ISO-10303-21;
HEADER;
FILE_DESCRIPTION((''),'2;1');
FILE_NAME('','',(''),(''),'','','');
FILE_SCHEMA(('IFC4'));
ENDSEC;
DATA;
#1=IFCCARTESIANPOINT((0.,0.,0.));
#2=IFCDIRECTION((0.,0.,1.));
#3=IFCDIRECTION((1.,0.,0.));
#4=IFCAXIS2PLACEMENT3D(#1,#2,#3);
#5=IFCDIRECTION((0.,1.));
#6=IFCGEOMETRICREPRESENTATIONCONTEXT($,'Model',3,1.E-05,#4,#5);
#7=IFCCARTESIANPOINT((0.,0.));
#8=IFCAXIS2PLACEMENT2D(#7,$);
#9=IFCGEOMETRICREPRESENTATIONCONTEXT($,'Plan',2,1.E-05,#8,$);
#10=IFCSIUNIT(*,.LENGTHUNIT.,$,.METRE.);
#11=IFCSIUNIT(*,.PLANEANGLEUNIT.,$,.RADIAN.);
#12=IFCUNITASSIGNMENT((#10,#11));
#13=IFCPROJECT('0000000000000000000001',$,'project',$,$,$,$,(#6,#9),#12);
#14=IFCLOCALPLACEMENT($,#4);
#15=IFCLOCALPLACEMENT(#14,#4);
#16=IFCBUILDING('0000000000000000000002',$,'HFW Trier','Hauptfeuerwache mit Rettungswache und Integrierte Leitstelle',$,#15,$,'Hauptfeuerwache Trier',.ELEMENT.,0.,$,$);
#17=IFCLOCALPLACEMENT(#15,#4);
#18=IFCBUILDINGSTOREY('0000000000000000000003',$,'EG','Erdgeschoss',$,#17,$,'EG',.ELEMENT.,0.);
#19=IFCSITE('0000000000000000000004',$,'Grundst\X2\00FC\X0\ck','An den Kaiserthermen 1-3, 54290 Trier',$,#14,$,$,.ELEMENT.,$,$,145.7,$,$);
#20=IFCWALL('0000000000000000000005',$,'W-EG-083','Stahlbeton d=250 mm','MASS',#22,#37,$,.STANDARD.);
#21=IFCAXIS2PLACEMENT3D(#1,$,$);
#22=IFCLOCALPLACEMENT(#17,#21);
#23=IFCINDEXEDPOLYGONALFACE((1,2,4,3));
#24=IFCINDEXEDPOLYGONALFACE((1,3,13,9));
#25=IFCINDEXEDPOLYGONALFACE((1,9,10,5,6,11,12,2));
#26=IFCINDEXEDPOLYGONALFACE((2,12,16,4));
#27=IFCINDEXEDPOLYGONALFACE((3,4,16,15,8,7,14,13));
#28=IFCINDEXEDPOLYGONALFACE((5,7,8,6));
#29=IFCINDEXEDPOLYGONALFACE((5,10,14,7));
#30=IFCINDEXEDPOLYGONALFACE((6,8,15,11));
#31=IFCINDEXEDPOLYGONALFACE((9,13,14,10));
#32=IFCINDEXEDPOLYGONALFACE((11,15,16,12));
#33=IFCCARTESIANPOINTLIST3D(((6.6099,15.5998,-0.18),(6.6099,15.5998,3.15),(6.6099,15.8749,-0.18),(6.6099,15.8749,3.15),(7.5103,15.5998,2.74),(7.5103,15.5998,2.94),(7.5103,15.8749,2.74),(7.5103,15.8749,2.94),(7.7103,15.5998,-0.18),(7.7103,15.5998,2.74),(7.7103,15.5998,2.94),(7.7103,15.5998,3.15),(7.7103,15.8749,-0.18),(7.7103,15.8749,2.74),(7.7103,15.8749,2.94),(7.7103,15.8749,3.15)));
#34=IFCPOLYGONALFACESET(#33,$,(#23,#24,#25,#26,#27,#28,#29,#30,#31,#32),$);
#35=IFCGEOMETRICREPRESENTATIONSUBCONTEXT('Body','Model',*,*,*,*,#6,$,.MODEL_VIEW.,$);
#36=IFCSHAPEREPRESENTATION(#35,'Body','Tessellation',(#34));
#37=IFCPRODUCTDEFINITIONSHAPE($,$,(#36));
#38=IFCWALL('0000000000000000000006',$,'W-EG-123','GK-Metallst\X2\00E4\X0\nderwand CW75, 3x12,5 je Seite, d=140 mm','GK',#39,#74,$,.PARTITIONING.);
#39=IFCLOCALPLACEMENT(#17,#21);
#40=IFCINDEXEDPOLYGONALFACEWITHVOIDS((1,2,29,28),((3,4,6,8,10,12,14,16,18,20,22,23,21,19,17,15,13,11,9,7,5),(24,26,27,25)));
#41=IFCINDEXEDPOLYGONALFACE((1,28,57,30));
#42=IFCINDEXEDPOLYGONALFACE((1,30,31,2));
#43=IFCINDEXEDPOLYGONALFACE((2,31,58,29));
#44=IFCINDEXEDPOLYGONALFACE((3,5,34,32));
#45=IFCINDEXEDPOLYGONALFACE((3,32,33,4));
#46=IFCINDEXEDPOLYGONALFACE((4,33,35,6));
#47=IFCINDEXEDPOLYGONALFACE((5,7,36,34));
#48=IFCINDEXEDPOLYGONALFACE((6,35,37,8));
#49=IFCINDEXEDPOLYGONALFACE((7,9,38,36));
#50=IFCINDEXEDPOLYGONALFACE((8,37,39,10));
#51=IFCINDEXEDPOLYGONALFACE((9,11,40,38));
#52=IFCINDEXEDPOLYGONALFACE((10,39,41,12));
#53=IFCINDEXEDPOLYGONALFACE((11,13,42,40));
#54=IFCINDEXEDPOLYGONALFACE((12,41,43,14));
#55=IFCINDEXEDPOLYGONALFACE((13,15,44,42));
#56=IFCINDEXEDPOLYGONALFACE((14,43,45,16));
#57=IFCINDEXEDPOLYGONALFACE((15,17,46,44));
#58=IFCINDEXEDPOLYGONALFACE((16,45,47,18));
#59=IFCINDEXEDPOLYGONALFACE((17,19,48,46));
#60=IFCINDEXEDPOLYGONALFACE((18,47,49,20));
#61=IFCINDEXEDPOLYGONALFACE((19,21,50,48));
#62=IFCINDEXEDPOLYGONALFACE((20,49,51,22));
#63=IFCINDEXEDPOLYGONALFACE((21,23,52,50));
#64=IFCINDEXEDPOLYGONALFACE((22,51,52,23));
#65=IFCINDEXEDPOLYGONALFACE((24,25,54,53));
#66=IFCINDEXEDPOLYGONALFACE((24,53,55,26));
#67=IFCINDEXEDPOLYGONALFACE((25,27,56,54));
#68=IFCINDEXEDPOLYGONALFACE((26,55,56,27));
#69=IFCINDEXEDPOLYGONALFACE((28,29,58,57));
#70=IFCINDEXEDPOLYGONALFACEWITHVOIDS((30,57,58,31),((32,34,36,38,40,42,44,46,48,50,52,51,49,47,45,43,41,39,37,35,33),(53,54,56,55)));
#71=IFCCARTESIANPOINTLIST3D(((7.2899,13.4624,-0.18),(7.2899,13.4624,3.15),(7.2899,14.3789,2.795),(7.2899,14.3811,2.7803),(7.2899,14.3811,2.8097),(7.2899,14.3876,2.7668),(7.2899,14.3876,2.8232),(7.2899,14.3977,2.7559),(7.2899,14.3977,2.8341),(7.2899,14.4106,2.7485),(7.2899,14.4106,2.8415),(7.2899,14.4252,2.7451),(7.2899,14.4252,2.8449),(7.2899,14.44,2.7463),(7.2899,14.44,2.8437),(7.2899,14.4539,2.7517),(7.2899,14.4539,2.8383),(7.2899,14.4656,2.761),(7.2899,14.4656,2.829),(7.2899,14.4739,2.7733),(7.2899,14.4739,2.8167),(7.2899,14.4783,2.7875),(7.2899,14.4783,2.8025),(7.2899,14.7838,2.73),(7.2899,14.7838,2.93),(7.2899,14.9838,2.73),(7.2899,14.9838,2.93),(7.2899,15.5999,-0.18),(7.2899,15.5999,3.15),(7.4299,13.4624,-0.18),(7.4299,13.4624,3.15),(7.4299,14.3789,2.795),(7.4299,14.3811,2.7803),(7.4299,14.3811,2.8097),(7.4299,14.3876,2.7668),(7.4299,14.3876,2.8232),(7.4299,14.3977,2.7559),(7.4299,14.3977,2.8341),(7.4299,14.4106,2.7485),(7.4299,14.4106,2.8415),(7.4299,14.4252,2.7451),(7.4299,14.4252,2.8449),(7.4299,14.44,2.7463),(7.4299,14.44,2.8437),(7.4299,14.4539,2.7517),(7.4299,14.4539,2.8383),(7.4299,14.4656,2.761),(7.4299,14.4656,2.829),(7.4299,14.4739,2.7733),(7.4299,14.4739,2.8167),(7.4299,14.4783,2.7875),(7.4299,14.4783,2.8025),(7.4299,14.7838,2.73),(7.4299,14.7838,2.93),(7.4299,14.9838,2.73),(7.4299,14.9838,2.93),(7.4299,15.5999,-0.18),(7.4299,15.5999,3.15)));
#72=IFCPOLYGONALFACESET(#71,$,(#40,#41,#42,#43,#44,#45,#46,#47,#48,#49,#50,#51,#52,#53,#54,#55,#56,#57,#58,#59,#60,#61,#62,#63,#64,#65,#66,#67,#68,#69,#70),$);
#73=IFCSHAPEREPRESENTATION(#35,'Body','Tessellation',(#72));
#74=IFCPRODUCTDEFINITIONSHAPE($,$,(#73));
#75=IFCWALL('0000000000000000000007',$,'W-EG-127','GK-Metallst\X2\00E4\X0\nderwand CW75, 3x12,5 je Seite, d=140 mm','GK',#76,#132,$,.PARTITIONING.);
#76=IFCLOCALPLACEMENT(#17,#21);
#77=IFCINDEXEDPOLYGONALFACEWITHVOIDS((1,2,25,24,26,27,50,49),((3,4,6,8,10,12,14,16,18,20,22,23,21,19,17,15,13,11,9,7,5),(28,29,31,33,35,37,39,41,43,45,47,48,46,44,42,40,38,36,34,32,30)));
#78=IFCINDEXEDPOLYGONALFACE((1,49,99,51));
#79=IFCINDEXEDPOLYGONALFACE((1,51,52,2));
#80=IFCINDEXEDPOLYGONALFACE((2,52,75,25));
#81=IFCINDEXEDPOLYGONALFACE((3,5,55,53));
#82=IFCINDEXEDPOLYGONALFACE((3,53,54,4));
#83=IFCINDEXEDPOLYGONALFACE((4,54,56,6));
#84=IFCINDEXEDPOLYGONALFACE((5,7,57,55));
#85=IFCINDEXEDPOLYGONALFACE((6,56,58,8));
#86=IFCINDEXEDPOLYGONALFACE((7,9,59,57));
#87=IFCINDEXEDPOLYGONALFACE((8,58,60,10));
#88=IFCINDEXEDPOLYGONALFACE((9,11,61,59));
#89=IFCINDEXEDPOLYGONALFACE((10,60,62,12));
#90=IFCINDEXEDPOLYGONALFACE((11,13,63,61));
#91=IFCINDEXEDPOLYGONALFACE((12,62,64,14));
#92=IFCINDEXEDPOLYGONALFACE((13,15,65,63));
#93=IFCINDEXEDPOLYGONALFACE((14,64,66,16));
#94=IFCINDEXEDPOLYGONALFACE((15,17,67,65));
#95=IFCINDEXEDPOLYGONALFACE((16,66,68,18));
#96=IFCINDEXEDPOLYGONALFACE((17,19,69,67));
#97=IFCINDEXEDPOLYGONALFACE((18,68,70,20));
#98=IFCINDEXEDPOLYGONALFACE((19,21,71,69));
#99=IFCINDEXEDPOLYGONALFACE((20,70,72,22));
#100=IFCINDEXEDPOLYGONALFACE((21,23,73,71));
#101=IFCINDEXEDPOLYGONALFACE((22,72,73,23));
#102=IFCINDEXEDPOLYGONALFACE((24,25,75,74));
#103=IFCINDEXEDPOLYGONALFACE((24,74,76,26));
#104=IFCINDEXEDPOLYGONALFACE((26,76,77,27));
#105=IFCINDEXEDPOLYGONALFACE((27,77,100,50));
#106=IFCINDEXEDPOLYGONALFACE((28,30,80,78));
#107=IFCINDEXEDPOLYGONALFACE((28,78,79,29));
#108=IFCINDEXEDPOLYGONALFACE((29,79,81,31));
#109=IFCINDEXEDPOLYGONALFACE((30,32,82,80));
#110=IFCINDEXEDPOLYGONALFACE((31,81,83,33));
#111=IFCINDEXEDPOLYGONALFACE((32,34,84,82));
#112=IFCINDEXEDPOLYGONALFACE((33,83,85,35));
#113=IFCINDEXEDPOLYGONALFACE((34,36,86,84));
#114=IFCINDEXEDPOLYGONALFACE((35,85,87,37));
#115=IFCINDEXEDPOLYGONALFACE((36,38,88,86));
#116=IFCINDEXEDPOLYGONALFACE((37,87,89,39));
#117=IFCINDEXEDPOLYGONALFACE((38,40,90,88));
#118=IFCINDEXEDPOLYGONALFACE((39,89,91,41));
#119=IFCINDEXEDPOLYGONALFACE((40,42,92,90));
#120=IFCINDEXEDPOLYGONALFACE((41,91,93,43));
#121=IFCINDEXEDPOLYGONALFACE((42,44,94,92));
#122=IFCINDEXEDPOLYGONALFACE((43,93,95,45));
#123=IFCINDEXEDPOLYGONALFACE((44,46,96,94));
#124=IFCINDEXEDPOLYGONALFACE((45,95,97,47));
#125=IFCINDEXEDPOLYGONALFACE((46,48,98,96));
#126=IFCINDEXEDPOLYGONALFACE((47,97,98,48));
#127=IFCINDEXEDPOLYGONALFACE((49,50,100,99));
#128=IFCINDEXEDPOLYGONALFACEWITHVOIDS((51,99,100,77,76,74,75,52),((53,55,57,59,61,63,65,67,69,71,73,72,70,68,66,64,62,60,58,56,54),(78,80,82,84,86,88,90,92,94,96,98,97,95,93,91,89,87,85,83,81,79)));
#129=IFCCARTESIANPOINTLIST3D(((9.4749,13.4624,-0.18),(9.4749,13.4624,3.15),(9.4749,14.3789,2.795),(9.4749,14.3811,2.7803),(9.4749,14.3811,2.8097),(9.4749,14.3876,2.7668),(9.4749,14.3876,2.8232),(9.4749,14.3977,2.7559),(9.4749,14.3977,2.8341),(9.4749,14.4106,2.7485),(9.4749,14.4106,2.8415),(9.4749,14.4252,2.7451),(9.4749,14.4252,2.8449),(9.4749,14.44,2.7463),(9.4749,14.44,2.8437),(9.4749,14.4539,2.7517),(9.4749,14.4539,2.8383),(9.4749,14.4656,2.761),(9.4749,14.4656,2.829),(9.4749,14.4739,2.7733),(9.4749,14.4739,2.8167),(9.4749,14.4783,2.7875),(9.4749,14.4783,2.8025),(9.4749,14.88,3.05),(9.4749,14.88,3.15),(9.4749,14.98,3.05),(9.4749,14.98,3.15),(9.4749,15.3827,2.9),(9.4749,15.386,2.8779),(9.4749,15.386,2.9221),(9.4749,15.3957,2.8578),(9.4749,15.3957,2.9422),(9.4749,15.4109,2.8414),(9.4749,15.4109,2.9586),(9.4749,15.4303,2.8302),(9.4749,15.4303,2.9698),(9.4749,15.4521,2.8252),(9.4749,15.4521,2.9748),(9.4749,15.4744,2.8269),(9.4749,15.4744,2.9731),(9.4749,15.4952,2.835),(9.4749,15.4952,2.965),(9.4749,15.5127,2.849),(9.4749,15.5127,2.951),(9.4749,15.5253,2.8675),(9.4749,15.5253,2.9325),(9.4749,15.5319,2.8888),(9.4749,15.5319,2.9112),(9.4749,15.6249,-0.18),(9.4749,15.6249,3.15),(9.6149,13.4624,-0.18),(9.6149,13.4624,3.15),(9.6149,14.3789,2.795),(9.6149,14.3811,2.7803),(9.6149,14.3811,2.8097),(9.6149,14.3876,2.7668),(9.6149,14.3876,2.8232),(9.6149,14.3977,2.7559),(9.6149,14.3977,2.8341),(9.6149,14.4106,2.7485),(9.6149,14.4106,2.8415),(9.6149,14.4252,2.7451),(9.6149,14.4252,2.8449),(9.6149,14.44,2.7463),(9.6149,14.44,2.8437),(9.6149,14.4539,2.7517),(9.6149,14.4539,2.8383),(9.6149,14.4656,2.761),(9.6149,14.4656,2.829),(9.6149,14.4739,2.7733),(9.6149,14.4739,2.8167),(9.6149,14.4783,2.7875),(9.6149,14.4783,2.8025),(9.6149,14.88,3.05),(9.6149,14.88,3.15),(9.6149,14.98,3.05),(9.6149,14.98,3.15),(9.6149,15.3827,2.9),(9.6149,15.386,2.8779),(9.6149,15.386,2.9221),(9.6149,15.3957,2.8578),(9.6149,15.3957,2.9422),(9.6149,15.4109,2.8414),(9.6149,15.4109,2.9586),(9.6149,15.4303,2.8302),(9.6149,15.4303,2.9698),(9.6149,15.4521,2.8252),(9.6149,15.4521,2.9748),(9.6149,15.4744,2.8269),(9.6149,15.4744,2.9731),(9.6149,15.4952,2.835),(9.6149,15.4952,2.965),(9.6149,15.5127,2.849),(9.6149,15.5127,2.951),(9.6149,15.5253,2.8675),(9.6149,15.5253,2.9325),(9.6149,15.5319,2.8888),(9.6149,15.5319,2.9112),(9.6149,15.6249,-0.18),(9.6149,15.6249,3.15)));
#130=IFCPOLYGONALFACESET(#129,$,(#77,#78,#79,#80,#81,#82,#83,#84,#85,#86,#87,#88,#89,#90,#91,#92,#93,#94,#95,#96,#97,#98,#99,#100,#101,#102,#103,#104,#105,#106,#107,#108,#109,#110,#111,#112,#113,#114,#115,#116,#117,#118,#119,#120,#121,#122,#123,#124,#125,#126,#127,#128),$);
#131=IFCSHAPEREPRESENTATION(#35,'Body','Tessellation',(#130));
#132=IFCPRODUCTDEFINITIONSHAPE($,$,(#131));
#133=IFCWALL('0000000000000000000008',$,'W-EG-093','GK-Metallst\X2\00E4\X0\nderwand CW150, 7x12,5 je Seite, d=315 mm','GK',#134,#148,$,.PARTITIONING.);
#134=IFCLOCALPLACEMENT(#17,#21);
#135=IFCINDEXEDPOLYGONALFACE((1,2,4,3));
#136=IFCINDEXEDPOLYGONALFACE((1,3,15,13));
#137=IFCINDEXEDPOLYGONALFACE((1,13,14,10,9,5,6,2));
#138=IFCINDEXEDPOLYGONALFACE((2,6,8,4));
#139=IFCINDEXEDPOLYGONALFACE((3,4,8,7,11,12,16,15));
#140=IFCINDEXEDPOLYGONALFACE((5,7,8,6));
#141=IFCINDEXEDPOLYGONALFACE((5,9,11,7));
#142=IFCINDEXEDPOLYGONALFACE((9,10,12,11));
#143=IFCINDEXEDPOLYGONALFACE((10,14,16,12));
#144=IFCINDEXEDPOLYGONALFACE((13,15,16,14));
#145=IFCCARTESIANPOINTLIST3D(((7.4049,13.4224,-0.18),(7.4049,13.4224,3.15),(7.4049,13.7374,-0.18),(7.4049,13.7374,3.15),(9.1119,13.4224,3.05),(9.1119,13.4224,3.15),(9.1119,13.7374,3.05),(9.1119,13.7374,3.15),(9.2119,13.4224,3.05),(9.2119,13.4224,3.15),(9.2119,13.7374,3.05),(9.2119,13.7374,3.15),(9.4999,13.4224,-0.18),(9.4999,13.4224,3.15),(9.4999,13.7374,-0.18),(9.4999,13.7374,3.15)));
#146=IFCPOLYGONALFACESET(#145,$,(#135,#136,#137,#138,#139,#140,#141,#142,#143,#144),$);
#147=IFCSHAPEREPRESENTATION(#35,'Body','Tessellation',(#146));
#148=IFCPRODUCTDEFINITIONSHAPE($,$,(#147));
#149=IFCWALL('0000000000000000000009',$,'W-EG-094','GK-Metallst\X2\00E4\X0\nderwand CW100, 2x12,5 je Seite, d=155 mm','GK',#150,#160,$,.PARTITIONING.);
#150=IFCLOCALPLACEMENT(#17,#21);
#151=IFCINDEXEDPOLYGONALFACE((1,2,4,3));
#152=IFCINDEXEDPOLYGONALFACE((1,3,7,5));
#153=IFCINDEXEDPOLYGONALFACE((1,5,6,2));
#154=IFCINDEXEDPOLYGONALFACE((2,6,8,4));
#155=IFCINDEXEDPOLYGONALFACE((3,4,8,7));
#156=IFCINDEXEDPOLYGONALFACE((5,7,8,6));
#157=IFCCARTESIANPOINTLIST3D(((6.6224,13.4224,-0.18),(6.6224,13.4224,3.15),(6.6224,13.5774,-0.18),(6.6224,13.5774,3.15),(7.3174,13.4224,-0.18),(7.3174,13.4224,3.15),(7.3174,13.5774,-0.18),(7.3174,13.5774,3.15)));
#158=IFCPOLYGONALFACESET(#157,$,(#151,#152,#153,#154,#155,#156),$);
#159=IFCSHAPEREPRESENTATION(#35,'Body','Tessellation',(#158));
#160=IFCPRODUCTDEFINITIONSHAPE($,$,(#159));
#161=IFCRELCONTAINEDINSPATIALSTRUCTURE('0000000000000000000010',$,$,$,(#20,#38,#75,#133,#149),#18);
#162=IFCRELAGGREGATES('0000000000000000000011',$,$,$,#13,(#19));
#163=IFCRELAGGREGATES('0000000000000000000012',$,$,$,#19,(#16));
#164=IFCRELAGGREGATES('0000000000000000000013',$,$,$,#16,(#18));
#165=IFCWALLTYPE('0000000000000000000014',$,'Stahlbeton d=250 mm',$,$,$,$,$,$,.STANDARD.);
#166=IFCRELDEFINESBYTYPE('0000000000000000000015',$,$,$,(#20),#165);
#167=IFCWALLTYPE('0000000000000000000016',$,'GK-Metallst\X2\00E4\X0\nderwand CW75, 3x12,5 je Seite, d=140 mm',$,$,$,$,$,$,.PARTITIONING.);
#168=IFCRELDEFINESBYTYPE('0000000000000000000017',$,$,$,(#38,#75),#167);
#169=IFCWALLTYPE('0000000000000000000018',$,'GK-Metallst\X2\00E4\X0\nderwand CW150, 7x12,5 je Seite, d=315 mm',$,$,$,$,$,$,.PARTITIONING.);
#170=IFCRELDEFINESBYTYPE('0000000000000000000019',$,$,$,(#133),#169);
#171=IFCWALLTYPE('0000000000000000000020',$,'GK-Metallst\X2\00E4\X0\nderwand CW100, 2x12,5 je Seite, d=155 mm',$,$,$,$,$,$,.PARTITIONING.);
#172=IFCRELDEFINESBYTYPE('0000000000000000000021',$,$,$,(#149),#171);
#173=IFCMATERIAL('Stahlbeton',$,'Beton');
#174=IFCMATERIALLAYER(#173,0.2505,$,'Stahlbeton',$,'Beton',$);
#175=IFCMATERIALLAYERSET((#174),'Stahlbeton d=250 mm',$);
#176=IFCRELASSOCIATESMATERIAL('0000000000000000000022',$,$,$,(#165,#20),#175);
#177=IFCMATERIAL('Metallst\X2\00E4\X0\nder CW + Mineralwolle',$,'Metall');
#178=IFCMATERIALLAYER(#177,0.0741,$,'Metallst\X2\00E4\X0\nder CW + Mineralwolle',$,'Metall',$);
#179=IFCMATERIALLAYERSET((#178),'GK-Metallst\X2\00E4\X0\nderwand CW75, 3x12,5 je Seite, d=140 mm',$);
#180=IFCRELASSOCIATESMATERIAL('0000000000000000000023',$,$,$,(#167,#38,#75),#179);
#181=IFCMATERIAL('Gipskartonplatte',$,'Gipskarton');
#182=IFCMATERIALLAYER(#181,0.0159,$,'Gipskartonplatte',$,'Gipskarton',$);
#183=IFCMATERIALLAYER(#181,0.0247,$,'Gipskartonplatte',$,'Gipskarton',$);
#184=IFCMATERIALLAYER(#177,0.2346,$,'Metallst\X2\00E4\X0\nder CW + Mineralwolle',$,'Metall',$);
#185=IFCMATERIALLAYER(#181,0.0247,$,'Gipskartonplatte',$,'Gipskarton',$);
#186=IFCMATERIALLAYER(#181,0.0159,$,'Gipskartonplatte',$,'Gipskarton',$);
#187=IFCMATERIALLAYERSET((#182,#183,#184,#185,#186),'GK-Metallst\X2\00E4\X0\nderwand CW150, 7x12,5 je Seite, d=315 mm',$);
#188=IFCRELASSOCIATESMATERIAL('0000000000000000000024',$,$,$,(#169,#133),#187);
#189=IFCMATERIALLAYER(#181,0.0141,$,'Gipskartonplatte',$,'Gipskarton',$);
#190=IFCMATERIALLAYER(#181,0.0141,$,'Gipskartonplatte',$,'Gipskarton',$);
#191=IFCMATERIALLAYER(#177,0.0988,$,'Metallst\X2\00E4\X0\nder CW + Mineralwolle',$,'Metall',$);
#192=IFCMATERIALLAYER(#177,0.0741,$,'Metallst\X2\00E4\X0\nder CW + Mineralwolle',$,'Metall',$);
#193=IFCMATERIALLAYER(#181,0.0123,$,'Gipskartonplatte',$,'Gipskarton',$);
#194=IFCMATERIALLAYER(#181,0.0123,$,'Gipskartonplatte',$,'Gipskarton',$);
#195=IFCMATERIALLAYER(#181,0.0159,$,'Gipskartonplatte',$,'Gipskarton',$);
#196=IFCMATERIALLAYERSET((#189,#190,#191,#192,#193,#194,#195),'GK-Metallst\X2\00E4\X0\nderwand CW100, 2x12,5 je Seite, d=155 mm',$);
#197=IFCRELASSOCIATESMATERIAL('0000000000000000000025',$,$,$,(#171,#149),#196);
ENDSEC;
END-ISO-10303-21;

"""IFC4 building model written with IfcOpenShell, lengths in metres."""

from ifc_helpers import new_model, si_unit, direction, frame, frame_2d, origin_with_axes, origin_2d, place, context, subcontext, project, spatial, rectangle, circle, extrude, material, layer, layer_set, layer_usage, type_object, element, save


model = new_model("IFC4")

# Units and contexts
model_context = context("Model", 3, precision=1e-05, world=origin_with_axes(), true_north=direction((0.0, 1.0)))
plan_context = context("Plan", 2, precision=1e-05, world=origin_2d())
body_context = subcontext(model_context, "Body", "Model", "MODEL_VIEW")
ifc_project = project(units=[si_unit("LENGTHUNIT", "METRE"), si_unit("PLANEANGLEUNIT", "RADIAN")], contexts=[model_context, plan_context])

# Site, building, storey
site_placement = place(None, origin_with_axes())
site = spatial("IfcSite", under=ifc_project, at=site_placement, Name="Grundstück", Description="An den Kaiserthermen 1-3, 54290 Trier", CompositionType="ELEMENT", RefElevation=145.7)
building_placement = place(site_placement, origin_with_axes())
building = spatial("IfcBuilding", under=site, at=building_placement, Name="HFW Trier", Description="Hauptfeuerwache mit Rettungswache und Integrierte Leitstelle", LongName="Hauptfeuerwache Trier", CompositionType="ELEMENT", ElevationOfRefHeight=0.0)
storey_placement = place(building_placement, origin_with_axes())
storey = spatial("IfcBuildingStorey", under=building, at=storey_placement, Name="EG", Description="Erdgeschoss", LongName="EG", CompositionType="ELEMENT", Elevation=0.0)

# Wall, opening
ifc_material_1 = material(Name="Stahlbeton", Category="Beton")
ifc_layer_1 = layer(ifc_material_1, 0.2505, Name="Stahlbeton", Category="Beton")
ifc_layer_set_1 = layer_set([ifc_layer_1], Name="Stahlbeton d=250 mm")
ifc_layer_usage_1 = layer_usage(ifc_layer_set_1, "AXIS2", "POSITIVE", -0.1376)
wall_type_1 = type_object("IfcWallType", Name="Stahlbeton d=250 mm", PredefinedType="STANDARD", material=ifc_layer_set_1)
wall_1_placement = place(storey_placement, frame((6.6099, 15.7374, -0.18), z_axis=(0.0, 0.0, 1.0), x_axis=(1.0, 0.0, 0.0)))
wall_1 = element("IfcWall", 1, at=wall_1_placement, inside=storey, type_object=wall_type_1, material=ifc_layer_usage_1, Name="W-EG-083", Description="Stahlbeton d=250 mm", ObjectType="MASS", PredefinedType="STANDARD", context=body_context, shape_type="SweptSolid", body=[
    extrude(rectangle(XDim=1.1004, YDim=0.2751, at=frame_2d((0.5502, 0.0))), origin_with_axes(), (0.0, 0.0, 1.0), 3.33),
])
opening_1_placement = place(wall_1_placement, origin_with_axes())
element("IfcOpeningElement", 2, at=opening_1_placement, cuts=wall_1, ObjectType="Wanddurchbruch", PredefinedType="OPENING", context=body_context, shape_type="SweptSolid", body=[
    extrude(rectangle(XDim=0.2, YDim=0.3751, at=frame_2d((1.0004, 0.0))), frame((0.0, 0.0, 2.92), z_axis=(0.0, 0.0, 1.0), x_axis=(1.0, 0.0, 0.0)), (0.0, 0.0, 1.0), 0.2),
])

# Walls, openings
ifc_material_2 = material(Name="Metallständer CW + Mineralwolle", Category="Metall")
ifc_layer_2 = layer(ifc_material_2, 0.0741, Name="Metallständer CW + Mineralwolle", Category="Metall")
ifc_layer_set_2 = layer_set([ifc_layer_2], Name="GK-Metallständerwand CW75, 3x12,5 je Seite, d=140 mm")
ifc_layer_usage_2 = layer_usage(ifc_layer_set_2, "AXIS2", "POSITIVE", -0.07)
wall_type_2 = type_object("IfcWallType", Name="GK-Metallständerwand CW75, 3x12,5 je Seite, d=140 mm", PredefinedType="PARTITIONING", material=ifc_layer_set_2)
wall_2_placement = place(storey_placement, frame((7.3599, 15.5999, -0.18), z_axis=(0.0, 0.0, 1.0), x_axis=(0.0, -1.0, 0.0)))
wall_2 = element("IfcWall", 3, at=wall_2_placement, inside=storey, type_object=wall_type_2, material=ifc_layer_usage_2, Name="W-EG-123", Description="GK-Metallständerwand CW75, 3x12,5 je Seite, d=140 mm", ObjectType="GK", PredefinedType="PARTITIONING", context=body_context, shape_type="SweptSolid", body=[
    extrude(rectangle(XDim=2.1375, YDim=0.14, at=frame_2d((1.0687, 0.0))), origin_with_axes(), (0.0, 0.0, 1.0), 3.33),
])
opening_2_placement = place(wall_2_placement, origin_with_axes())
element("IfcOpeningElement", 4, at=opening_2_placement, cuts=wall_2, ObjectType="Wanddurchbruch", PredefinedType="OPENING", context=body_context, shape_type="SweptSolid", body=[
    extrude(circle(Radius=0.05, at=origin_2d()), frame((1.171, -0.12, 2.975), z_axis=(0.0, 1.0, 0.0), x_axis=(1.0, 0.0, 0.0)), (0.0, 0.0, 1.0), 0.24),
])
opening_3_placement = place(wall_2_placement, origin_with_axes())
element("IfcOpeningElement", 5, at=opening_3_placement, cuts=wall_2, ObjectType="Wanddurchbruch", PredefinedType="OPENING", context=body_context, shape_type="SweptSolid", body=[
    extrude(rectangle(XDim=0.2, YDim=0.24, at=frame_2d((0.7161, 0.0))), frame((0.0, 0.0, 2.91), z_axis=(0.0, 0.0, 1.0), x_axis=(1.0, 0.0, 0.0)), (0.0, 0.0, 1.0), 0.2),
])
ifc_layer_usage_3 = layer_usage(ifc_layer_set_2, "AXIS2", "POSITIVE", -0.07)
wall_3_placement = place(storey_placement, frame((9.5449, 15.6249, -0.18), z_axis=(0.0, 0.0, 1.0), x_axis=(0.0, -1.0, 0.0)))
wall_3 = element("IfcWall", 6, at=wall_3_placement, inside=storey, type_object=wall_type_2, material=ifc_layer_usage_3, Name="W-EG-127", Description="GK-Metallständerwand CW75, 3x12,5 je Seite, d=140 mm", ObjectType="GK", PredefinedType="PARTITIONING", context=body_context, shape_type="SweptSolid", body=[
    extrude(rectangle(XDim=2.1625, YDim=0.14, at=frame_2d((1.0812, 0.0))), origin_with_axes(), (0.0, 0.0, 1.0), 3.33),
])
opening_4_placement = place(wall_3_placement, origin_with_axes())
element("IfcOpeningElement", 7, at=opening_4_placement, cuts=wall_3, ObjectType="Wanddurchbruch", PredefinedType="OPENING", context=body_context, shape_type="SweptSolid", body=[
    extrude(circle(Radius=0.05, at=origin_2d()), frame((1.196, -0.12, 2.975), z_axis=(0.0, 1.0, 0.0), x_axis=(1.0, 0.0, 0.0)), (0.0, 0.0, 1.0), 0.24),
])
opening_5_placement = place(wall_3_placement, origin_with_axes())
element("IfcOpeningElement", 8, at=opening_5_placement, cuts=wall_3, ObjectType="Wanddurchbruch", PredefinedType="OPENING", context=body_context, shape_type="SweptSolid", body=[
    extrude(circle(Radius=0.075, at=origin_2d()), frame((0.1672, -0.12, 3.08), z_axis=(0.0, 1.0, 0.0), x_axis=(1.0, 0.0, 0.0)), (0.0, 0.0, 1.0), 0.24),
])
opening_6_placement = place(wall_3_placement, origin_with_axes())
element("IfcOpeningElement", 9, at=opening_6_placement, cuts=wall_3, ObjectType="Wanddurchbruch", PredefinedType="OPENING", context=body_context, shape_type="SweptSolid", body=[
    extrude(rectangle(XDim=0.1, YDim=0.24, at=frame_2d((0.6949, 0.0))), frame((0.0, 0.0, 3.23), z_axis=(0.0, 0.0, 1.0), x_axis=(1.0, 0.0, 0.0)), (0.0, 0.0, 1.0), 0.1),
])

# Wall, opening
ifc_material_3 = material(Name="Gipskartonplatte", Category="Gipskarton")
ifc_layer_3 = layer(ifc_material_3, 0.0159, Name="Gipskartonplatte", Category="Gipskarton")
ifc_layer_4 = layer(ifc_material_3, 0.0247, Name="Gipskartonplatte", Category="Gipskarton")
ifc_layer_5 = layer(ifc_material_2, 0.2346, Name="Metallständer CW + Mineralwolle", Category="Metall")
ifc_layer_6 = layer(ifc_material_3, 0.0247, Name="Gipskartonplatte", Category="Gipskarton")
ifc_layer_7 = layer(ifc_material_3, 0.0159, Name="Gipskartonplatte", Category="Gipskarton")
ifc_layer_set_3 = layer_set([ifc_layer_3, ifc_layer_4, ifc_layer_5, ifc_layer_6, ifc_layer_7], Name="GK-Metallständerwand CW150, 7x12,5 je Seite, d=315 mm")
ifc_layer_usage_4 = layer_usage(ifc_layer_set_3, "AXIS2", "POSITIVE", -0.1575)
wall_type_3 = type_object("IfcWallType", Name="GK-Metallständerwand CW150, 7x12,5 je Seite, d=315 mm", PredefinedType="PARTITIONING", material=ifc_layer_set_3)
wall_4_placement = place(storey_placement, frame((7.4049, 13.5799, -0.18), z_axis=(0.0, 0.0, 1.0), x_axis=(1.0, 0.0, 0.0)))
wall_4 = element("IfcWall", 10, at=wall_4_placement, inside=storey, type_object=wall_type_3, material=ifc_layer_usage_4, Name="W-EG-093", Description="GK-Metallständerwand CW150, 7x12,5 je Seite, d=315 mm", ObjectType="GK", PredefinedType="PARTITIONING", context=body_context, shape_type="SweptSolid", body=[
    extrude(rectangle(XDim=2.095, YDim=0.315, at=frame_2d((1.0475, 0.0))), origin_with_axes(), (0.0, 0.0, 1.0), 3.33),
])
opening_7_placement = place(wall_4_placement, origin_with_axes())
element("IfcOpeningElement", 11, at=opening_7_placement, cuts=wall_4, ObjectType="Wanddurchbruch", PredefinedType="OPENING", context=body_context, shape_type="SweptSolid", body=[
    extrude(rectangle(XDim=0.1, YDim=0.415, at=frame_2d((1.757, 0.0))), frame((0.0, 0.0, 3.23), z_axis=(0.0, 0.0, 1.0), x_axis=(1.0, 0.0, 0.0)), (0.0, 0.0, 1.0), 0.1),
])

# Wall
ifc_layer_8 = layer(ifc_material_3, 0.0141, Name="Gipskartonplatte", Category="Gipskarton")
ifc_layer_9 = layer(ifc_material_3, 0.0141, Name="Gipskartonplatte", Category="Gipskarton")
ifc_layer_10 = layer(ifc_material_2, 0.0988, Name="Metallständer CW + Mineralwolle", Category="Metall")
ifc_layer_11 = layer(ifc_material_2, 0.0741, Name="Metallständer CW + Mineralwolle", Category="Metall")
ifc_layer_12 = layer(ifc_material_3, 0.0123, Name="Gipskartonplatte", Category="Gipskarton")
ifc_layer_13 = layer(ifc_material_3, 0.0123, Name="Gipskartonplatte", Category="Gipskarton")
ifc_layer_14 = layer(ifc_material_3, 0.0159, Name="Gipskartonplatte", Category="Gipskarton")
ifc_layer_set_4 = layer_set([ifc_layer_8, ifc_layer_9, ifc_layer_10, ifc_layer_11, ifc_layer_12, ifc_layer_13, ifc_layer_14], Name="GK-Metallständerwand CW100, 2x12,5 je Seite, d=155 mm")
ifc_layer_usage_5 = layer_usage(ifc_layer_set_4, "AXIS2", "POSITIVE", -0.0775)
wall_type_4 = type_object("IfcWallType", Name="GK-Metallständerwand CW100, 2x12,5 je Seite, d=155 mm", PredefinedType="PARTITIONING", material=ifc_layer_set_4)
wall_5_placement = place(storey_placement, frame((6.6224, 13.4999, -0.18), z_axis=(0.0, 0.0, 1.0), x_axis=(1.0, 0.0, 0.0)))
element("IfcWall", 12, at=wall_5_placement, inside=storey, type_object=wall_type_4, material=ifc_layer_usage_5, Name="W-EG-094", Description="GK-Metallständerwand CW100, 2x12,5 je Seite, d=155 mm", ObjectType="GK", PredefinedType="PARTITIONING", context=body_context, shape_type="SweptSolid", body=[
    extrude(rectangle(XDim=0.695, YDim=0.155, at=frame_2d((0.3475, 0.0))), origin_with_axes(), (0.0, 0.0, 1.0), 3.33),
])

save(model, "model.ifc")
